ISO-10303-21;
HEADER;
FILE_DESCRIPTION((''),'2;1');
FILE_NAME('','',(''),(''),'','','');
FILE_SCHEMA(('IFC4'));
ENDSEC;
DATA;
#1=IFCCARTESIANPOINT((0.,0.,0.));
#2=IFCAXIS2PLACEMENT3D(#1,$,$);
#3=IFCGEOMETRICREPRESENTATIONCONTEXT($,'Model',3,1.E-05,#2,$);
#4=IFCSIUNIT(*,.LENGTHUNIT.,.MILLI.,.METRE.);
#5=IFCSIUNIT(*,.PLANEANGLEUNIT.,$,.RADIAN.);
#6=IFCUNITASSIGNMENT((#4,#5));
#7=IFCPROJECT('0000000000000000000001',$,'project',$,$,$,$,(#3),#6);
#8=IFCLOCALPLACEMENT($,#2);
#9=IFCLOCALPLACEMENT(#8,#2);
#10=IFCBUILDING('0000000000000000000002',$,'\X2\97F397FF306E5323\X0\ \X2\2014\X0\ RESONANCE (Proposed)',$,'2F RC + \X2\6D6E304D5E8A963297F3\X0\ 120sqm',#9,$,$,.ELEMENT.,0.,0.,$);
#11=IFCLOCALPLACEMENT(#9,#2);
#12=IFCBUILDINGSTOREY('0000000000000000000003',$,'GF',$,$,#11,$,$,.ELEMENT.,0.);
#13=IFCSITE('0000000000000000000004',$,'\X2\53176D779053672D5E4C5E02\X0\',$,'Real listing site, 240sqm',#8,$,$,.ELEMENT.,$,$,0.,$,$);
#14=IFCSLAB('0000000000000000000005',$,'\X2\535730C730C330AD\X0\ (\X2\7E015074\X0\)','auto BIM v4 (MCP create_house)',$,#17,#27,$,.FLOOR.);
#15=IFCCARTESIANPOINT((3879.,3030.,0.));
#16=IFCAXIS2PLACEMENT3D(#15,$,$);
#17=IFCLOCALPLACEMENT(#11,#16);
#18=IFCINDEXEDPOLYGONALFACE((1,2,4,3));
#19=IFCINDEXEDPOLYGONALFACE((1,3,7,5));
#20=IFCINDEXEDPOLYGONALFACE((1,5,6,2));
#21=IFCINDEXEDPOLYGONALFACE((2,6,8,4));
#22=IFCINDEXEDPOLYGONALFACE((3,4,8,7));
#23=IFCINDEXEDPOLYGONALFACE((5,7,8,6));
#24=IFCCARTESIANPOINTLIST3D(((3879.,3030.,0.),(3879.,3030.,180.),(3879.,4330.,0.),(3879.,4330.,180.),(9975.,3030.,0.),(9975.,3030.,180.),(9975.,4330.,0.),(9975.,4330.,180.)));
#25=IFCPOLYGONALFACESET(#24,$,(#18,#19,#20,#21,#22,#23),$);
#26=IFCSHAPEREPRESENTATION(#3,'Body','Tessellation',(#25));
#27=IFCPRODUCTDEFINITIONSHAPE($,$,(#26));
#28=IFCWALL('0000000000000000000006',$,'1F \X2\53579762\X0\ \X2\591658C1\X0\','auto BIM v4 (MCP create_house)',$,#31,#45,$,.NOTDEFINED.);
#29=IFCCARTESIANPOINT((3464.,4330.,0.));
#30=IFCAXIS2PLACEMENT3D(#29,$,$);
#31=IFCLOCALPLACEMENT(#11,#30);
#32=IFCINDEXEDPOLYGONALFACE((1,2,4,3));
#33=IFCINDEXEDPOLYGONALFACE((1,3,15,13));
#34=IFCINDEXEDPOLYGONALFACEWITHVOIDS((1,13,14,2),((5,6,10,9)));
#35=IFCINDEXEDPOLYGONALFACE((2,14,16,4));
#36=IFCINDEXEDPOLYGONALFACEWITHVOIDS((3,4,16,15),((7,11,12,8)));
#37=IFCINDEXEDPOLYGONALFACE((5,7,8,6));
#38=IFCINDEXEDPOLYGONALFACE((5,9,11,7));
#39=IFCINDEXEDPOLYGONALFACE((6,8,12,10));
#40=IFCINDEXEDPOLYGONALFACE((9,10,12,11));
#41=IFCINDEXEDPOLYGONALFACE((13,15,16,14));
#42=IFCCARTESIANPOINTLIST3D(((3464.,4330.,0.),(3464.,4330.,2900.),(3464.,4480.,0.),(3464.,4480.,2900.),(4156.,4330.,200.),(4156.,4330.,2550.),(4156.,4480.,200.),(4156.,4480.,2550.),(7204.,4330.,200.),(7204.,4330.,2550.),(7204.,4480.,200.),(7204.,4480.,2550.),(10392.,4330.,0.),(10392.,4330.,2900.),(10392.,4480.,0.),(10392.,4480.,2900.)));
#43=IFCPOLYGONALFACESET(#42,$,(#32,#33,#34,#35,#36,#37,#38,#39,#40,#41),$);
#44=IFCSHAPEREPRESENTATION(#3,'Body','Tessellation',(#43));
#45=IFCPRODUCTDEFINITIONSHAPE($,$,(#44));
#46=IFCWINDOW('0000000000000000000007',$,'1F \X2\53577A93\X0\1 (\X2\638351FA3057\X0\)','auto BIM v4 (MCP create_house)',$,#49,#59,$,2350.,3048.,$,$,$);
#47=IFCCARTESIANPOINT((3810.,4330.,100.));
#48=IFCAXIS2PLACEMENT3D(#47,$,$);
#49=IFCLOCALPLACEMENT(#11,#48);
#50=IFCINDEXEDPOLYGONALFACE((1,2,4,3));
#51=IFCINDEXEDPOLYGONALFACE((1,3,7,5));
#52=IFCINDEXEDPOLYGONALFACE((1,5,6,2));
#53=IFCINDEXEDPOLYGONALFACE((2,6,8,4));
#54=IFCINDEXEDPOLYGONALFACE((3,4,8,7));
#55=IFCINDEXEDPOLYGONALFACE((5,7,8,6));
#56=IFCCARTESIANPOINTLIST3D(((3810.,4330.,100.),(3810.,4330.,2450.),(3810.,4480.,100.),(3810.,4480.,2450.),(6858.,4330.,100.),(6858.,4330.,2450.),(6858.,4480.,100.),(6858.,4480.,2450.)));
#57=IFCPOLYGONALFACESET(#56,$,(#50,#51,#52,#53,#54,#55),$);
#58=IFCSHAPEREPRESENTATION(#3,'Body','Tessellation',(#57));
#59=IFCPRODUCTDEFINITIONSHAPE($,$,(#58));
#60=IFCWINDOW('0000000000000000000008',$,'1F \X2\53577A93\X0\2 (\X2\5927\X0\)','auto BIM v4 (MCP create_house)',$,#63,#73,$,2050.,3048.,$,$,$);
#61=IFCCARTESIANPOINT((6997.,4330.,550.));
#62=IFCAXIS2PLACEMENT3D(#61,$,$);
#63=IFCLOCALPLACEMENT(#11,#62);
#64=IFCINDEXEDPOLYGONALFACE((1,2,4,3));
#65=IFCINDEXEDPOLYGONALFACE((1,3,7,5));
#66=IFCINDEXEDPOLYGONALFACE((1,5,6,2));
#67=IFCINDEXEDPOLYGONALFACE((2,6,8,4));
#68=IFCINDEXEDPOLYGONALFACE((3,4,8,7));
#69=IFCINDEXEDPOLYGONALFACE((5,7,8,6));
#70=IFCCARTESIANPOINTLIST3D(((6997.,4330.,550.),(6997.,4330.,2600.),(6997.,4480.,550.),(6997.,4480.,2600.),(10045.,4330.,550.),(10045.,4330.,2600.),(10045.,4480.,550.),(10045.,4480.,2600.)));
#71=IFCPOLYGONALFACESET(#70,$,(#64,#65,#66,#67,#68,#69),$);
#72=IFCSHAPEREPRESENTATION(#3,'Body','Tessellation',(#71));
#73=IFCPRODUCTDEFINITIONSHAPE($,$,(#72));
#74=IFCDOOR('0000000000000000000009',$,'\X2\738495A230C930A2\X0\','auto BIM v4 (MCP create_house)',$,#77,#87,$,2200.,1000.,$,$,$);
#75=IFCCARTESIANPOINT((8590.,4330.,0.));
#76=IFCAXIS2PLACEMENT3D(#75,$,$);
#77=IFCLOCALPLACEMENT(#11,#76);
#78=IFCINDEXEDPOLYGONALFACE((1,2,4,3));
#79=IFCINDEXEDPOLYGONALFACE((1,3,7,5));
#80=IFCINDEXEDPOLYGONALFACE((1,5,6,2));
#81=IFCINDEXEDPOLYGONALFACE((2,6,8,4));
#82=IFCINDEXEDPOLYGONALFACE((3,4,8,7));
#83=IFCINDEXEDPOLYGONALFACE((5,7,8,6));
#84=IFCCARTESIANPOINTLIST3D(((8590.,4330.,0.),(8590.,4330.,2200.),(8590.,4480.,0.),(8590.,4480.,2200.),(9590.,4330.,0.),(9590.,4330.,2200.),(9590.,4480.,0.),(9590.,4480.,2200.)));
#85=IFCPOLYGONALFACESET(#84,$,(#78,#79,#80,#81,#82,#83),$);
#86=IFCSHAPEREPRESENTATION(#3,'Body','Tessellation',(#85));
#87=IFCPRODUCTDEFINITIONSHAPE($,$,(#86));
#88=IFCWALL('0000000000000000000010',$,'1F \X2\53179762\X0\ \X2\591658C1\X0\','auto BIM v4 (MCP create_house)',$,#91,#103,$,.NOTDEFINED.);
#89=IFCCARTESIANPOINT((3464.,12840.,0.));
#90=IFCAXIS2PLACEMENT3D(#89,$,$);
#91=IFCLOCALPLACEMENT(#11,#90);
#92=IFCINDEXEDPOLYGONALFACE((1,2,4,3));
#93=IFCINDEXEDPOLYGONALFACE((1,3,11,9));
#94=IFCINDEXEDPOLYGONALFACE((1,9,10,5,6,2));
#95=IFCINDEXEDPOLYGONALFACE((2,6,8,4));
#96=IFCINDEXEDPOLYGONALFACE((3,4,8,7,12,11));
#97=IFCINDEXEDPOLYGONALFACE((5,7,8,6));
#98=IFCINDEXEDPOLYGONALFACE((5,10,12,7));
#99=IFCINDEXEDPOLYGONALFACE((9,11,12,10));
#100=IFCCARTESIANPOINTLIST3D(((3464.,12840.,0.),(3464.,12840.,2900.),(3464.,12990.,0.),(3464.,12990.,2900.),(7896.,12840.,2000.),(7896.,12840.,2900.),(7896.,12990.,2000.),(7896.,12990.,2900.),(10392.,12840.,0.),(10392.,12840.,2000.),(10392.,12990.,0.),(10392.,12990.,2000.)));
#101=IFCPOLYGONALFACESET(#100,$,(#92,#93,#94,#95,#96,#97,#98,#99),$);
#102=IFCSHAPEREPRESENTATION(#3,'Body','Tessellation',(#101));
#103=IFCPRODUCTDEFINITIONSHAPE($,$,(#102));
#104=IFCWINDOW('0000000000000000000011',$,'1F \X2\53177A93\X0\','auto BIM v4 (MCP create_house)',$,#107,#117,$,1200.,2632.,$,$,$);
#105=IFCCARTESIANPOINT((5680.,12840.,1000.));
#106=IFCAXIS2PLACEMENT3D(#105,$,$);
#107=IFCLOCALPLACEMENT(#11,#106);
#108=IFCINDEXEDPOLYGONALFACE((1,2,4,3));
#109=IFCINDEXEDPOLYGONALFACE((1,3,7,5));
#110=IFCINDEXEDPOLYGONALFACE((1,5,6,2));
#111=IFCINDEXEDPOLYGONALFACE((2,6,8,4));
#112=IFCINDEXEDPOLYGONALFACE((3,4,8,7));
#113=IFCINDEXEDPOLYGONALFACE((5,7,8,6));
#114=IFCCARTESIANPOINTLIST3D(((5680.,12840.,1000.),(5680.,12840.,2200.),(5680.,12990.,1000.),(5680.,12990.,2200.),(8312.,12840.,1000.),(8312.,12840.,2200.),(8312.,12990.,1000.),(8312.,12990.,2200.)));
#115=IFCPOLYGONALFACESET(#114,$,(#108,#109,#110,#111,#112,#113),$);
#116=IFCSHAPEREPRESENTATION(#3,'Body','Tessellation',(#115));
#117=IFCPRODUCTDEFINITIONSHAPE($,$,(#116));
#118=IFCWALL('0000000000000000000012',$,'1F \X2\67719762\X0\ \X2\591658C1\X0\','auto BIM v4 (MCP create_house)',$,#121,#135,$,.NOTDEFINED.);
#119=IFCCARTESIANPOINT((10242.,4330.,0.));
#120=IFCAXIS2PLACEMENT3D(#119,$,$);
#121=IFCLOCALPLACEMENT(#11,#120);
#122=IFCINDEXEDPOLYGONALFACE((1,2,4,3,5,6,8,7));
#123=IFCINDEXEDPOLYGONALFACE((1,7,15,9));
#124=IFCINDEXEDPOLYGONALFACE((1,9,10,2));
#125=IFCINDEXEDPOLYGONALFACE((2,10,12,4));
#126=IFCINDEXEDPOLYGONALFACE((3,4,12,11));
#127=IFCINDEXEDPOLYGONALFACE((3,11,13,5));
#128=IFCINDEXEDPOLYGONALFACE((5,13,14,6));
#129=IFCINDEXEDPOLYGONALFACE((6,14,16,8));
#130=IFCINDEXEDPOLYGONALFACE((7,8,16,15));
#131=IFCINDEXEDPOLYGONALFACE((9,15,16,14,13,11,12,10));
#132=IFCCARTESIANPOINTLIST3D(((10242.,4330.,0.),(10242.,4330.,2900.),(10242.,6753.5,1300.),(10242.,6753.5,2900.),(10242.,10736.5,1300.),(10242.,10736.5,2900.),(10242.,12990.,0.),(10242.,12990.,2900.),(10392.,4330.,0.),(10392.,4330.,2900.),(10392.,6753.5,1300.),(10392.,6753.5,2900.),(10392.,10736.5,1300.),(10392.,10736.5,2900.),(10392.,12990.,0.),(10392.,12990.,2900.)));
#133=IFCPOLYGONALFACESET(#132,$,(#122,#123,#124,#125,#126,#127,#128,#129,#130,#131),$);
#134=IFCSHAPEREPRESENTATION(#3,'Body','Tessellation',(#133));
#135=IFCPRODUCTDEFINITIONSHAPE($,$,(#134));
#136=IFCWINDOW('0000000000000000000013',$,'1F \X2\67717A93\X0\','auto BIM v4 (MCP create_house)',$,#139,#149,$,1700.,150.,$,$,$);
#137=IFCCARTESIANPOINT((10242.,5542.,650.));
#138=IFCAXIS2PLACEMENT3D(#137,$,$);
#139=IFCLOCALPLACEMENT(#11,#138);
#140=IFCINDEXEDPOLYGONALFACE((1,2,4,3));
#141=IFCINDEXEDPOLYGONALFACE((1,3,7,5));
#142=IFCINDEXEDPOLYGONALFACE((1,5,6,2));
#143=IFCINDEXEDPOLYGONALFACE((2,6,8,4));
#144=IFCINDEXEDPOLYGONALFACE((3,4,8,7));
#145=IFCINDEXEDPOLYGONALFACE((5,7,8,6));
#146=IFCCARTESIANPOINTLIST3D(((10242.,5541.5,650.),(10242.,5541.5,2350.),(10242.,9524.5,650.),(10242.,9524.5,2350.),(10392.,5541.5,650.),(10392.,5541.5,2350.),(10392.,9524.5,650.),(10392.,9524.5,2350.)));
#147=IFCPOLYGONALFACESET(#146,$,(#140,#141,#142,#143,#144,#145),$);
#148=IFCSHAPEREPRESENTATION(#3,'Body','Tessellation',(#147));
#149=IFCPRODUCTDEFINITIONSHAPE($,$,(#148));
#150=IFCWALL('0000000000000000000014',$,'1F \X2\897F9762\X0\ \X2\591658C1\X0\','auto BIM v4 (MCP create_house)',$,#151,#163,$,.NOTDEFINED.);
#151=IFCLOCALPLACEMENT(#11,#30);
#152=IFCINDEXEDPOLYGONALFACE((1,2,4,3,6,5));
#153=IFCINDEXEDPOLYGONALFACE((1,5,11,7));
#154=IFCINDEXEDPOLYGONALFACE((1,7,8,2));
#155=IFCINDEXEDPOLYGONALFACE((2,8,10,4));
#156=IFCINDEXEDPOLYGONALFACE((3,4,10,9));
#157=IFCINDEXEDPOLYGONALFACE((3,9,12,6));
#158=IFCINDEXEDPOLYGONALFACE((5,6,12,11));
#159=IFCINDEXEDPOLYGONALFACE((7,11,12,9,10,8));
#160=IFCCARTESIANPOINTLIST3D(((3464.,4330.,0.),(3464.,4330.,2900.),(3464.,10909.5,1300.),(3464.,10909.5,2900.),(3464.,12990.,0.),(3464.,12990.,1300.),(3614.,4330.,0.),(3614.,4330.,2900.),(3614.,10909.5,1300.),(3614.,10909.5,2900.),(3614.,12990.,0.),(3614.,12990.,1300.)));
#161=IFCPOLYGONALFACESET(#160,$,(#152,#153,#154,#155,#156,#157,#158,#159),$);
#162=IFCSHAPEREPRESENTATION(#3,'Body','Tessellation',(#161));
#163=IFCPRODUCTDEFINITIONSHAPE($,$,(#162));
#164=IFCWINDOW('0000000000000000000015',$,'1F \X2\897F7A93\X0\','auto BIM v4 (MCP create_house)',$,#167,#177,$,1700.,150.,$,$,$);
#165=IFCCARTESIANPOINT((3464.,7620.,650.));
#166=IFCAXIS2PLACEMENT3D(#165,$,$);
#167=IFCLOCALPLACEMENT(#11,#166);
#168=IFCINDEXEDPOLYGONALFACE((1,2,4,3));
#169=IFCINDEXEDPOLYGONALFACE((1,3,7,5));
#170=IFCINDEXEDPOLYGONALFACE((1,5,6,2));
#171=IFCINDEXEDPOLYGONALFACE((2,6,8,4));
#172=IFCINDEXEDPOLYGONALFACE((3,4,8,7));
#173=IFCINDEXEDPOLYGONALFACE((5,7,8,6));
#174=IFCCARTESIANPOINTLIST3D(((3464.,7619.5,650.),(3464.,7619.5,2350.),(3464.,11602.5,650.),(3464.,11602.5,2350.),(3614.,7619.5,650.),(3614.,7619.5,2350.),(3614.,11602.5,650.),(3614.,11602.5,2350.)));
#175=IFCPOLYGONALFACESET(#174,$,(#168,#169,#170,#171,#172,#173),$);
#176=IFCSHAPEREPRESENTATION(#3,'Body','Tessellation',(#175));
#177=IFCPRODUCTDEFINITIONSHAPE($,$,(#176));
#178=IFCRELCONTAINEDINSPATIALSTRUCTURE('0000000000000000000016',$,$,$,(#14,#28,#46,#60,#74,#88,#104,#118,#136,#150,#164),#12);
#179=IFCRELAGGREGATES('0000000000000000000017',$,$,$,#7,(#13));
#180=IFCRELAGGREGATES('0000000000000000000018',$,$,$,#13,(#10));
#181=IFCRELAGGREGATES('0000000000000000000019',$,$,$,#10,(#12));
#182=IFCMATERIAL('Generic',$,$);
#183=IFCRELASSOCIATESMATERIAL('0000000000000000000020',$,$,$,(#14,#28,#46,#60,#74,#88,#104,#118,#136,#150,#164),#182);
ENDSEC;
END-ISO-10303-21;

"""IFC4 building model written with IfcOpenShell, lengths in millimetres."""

from ifc_helpers import new_model, si_unit, frame, frame_2d, origin, place, context, project, spatial, rectangle, extrude, material, element, fill, save


model = new_model("IFC4")

# Units and contexts
model_context = context("Model", 3, precision=1e-05, world=origin())
ifc_project = project(units=[si_unit("LENGTHUNIT", "METRE", prefix="MILLI"), si_unit("PLANEANGLEUNIT", "RADIAN")], contexts=[model_context])

# Site, building, storey
site_placement = place(None, origin())
site = spatial("IfcSite", under=ifc_project, at=site_placement, Name="北海道札幌市", ObjectType="Real listing site, 240sqm", CompositionType="ELEMENT", RefElevation=0.0)
building_placement = place(site_placement, origin())
building = spatial("IfcBuilding", under=site, at=building_placement, Name="音響の匣 — RESONANCE (Proposed)", ObjectType="2F RC + 浮き床防音 120sqm", CompositionType="ELEMENT", ElevationOfRefHeight=0.0, ElevationOfTerrain=0.0)
storey_placement = place(building_placement, origin())
storey = spatial("IfcBuildingStorey", under=building, at=storey_placement, Name="GF", CompositionType="ELEMENT", Elevation=0.0)

# Slab
ifc_material = material(Name="Generic")
slab_1_placement = place(storey_placement, frame((3879.0, 3030.0, 0.0)))
element("IfcSlab", 1, at=slab_1_placement, inside=storey, material=ifc_material, Name="南デッキ (縁側)", Description="auto BIM v4 (MCP create_house)", PredefinedType="FLOOR", context=model_context, shape_type="SweptSolid", body=[
    extrude(rectangle(XDim=6096.0, YDim=1300.0, at=frame_2d((3048.0, 650.0))), frame((3879.0, 3030.0, 0.0)), (0.0, 0.0, 1.0), 180.0),
])

# Wall, openings, windows, door
wall_1_placement = place(storey_placement, frame((3464.0, 4330.0, 0.0)))
wall_1 = element("IfcWall", 2, at=wall_1_placement, inside=storey, material=ifc_material, Name="1F 南面 外壁", Description="auto BIM v4 (MCP create_house)", PredefinedType="NOTDEFINED", context=model_context, shape_type="SweptSolid", body=[
    extrude(rectangle(XDim=6928.0, YDim=150.0, at=frame_2d((3464.0, 75.0))), frame((3464.0, 4330.0, 0.0)), (0.0, 0.0, 1.0), 2900.0),
])
opening_1_placement = place(storey_placement, frame((3810.0, 4330.0, 100.0)))
opening_1 = element("IfcOpeningElement", 3, at=opening_1_placement, cuts=wall_1, PredefinedType="NOTDEFINED", context=model_context, shape_type="SweptSolid", body=[
    extrude(rectangle(XDim=3048.0, YDim=150.0, at=frame_2d((1524.0, 75.0))), frame((3810.0, 4330.0, 100.0)), (0.0, 0.0, 1.0), 2350.0),
])
opening_2_placement = place(storey_placement, frame((6997.0, 4330.0, 550.0)))
opening_2 = element("IfcOpeningElement", 4, at=opening_2_placement, cuts=wall_1, PredefinedType="NOTDEFINED", context=model_context, shape_type="SweptSolid", body=[
    extrude(rectangle(XDim=3048.0, YDim=150.0, at=frame_2d((1524.0, 75.0))), frame((6997.0, 4330.0, 550.0)), (0.0, 0.0, 1.0), 2050.0),
])
opening_3_placement = place(storey_placement, frame((8590.0, 4330.0, 0.0)))
opening_3 = element("IfcOpeningElement", 5, at=opening_3_placement, cuts=wall_1, PredefinedType="NOTDEFINED", context=model_context, shape_type="SweptSolid", body=[
    extrude(rectangle(XDim=1000.0, YDim=150.0, at=frame_2d((500.0, 75.0))), frame((8590.0, 4330.0, 0.0)), (0.0, 0.0, 1.0), 2200.0),
])
window_1_placement = place(storey_placement, frame((3810.0, 4330.0, 100.0)))
window_1 = element("IfcWindow", 6, at=window_1_placement, inside=storey, material=ifc_material, Name="1F 南窓1 (掃出し)", Description="auto BIM v4 (MCP create_house)", OverallHeight=2350.0, OverallWidth=3048.0, context=model_context, shape_type="SweptSolid", body=[
    extrude(rectangle(XDim=3048.0, YDim=150.0, at=frame_2d((1524.0, 75.0))), frame((3810.0, 4330.0, 100.0)), (0.0, 0.0, 1.0), 2350.0),
])
fill(opening_1, window_1)
window_2_placement = place(storey_placement, frame((6997.0, 4330.0, 550.0)))
window_2 = element("IfcWindow", 7, at=window_2_placement, inside=storey, material=ifc_material, Name="1F 南窓2 (大)", Description="auto BIM v4 (MCP create_house)", OverallHeight=2050.0, OverallWidth=3048.0, context=model_context, shape_type="SweptSolid", body=[
    extrude(rectangle(XDim=3048.0, YDim=150.0, at=frame_2d((1524.0, 75.0))), frame((6997.0, 4330.0, 550.0)), (0.0, 0.0, 1.0), 2050.0),
])
fill(opening_2, window_2)
door_1_placement = place(storey_placement, frame((8590.0, 4330.0, 0.0)))
door_1 = element("IfcDoor", 8, at=door_1_placement, inside=storey, material=ifc_material, Name="玄関ドア", Description="auto BIM v4 (MCP create_house)", OverallHeight=2200.0, OverallWidth=1000.0, context=model_context, shape_type="SweptSolid", body=[
    extrude(rectangle(XDim=1000.0, YDim=150.0, at=frame_2d((500.0, 75.0))), frame((8590.0, 4330.0, 0.0)), (0.0, 0.0, 1.0), 2200.0),
])
fill(opening_3, door_1)

# Walls, openings, windows
wall_2_placement = place(storey_placement, frame((3464.0, 12840.0, 0.0)))
wall_2 = element("IfcWall", 9, at=wall_2_placement, inside=storey, material=ifc_material, Name="1F 北面 外壁", Description="auto BIM v4 (MCP create_house)", PredefinedType="NOTDEFINED", context=model_context, shape_type="SweptSolid", body=[
    extrude(rectangle(XDim=6928.0, YDim=150.0, at=frame_2d((3464.0, 75.0))), frame((3464.0, 12840.0, 0.0)), (0.0, 0.0, 1.0), 2900.0),
])
opening_4_placement = place(storey_placement, frame((5680.0, 12840.0, 1000.0)))
opening_4 = element("IfcOpeningElement", 10, at=opening_4_placement, cuts=wall_2, PredefinedType="NOTDEFINED", context=model_context, shape_type="SweptSolid", body=[
    extrude(rectangle(XDim=2632.0, YDim=150.0, at=frame_2d((1316.0, 75.0))), frame((5680.0, 12840.0, 1000.0)), (0.0, 0.0, 1.0), 1200.0),
])
window_3_placement = place(storey_placement, frame((5680.0, 12840.0, 1000.0)))
window_3 = element("IfcWindow", 11, at=window_3_placement, inside=storey, material=ifc_material, Name="1F 北窓", Description="auto BIM v4 (MCP create_house)", OverallHeight=1200.0, OverallWidth=2632.0, context=model_context, shape_type="SweptSolid", body=[
    extrude(rectangle(XDim=2632.0, YDim=150.0, at=frame_2d((1316.0, 75.0))), frame((5680.0, 12840.0, 1000.0)), (0.0, 0.0, 1.0), 1200.0),
])
fill(opening_4, window_3)
wall_3_placement = place(storey_placement, frame((10242.0, 4330.0, 0.0)))
wall_3 = element("IfcWall", 12, at=wall_3_placement, inside=storey, material=ifc_material, Name="1F 東面 外壁", Description="auto BIM v4 (MCP create_house)", PredefinedType="NOTDEFINED", context=model_context, shape_type="SweptSolid", body=[
    extrude(rectangle(XDim=150.0, YDim=8660.0, at=frame_2d((75.0, 4330.0))), frame((10242.0, 4330.0, 0.0)), (0.0, 0.0, 1.0), 2900.0),
])
opening_5_placement = place(storey_placement, frame((10242.0, 5542.0, 650.0)))
opening_5 = element("IfcOpeningElement", 13, at=opening_5_placement, cuts=wall_3, PredefinedType="NOTDEFINED", context=model_context, shape_type="SweptSolid", body=[
    extrude(rectangle(XDim=150.0, YDim=3983.0, at=frame_2d((75.0, 1991.0))), frame((10242.0, 5542.0, 650.0)), (0.0, 0.0, 1.0), 1700.0),
])
window_4_placement = place(storey_placement, frame((10242.0, 5542.0, 650.0)))
window_4 = element("IfcWindow", 14, at=window_4_placement, inside=storey, material=ifc_material, Name="1F 東窓", Description="auto BIM v4 (MCP create_house)", OverallHeight=1700.0, OverallWidth=150.0, context=model_context, shape_type="SweptSolid", body=[
    extrude(rectangle(XDim=150.0, YDim=3983.0, at=frame_2d((75.0, 1991.0))), frame((10242.0, 5542.0, 650.0)), (0.0, 0.0, 1.0), 1700.0),
])
fill(opening_5, window_4)
wall_4_placement = place(storey_placement, frame((3464.0, 4330.0, 0.0)))
wall_4 = element("IfcWall", 15, at=wall_4_placement, inside=storey, material=ifc_material, Name="1F 西面 外壁", Description="auto BIM v4 (MCP create_house)", PredefinedType="NOTDEFINED", context=model_context, shape_type="SweptSolid", body=[
    extrude(rectangle(XDim=150.0, YDim=8660.0, at=frame_2d((75.0, 4330.0))), frame((3464.0, 4330.0, 0.0)), (0.0, 0.0, 1.0), 2900.0),
])
opening_6_placement = place(storey_placement, frame((3464.0, 7620.0, 650.0)))
opening_6 = element("IfcOpeningElement", 16, at=opening_6_placement, cuts=wall_4, PredefinedType="NOTDEFINED", context=model_context, shape_type="SweptSolid", body=[
    extrude(rectangle(XDim=150.0, YDim=3983.0, at=frame_2d((75.0, 1991.0))), frame((3464.0, 7620.0, 650.0)), (0.0, 0.0, 1.0), 1700.0),
])
window_5_placement = place(storey_placement, frame((3464.0, 7620.0, 650.0)))
window_5 = element("IfcWindow", 17, at=window_5_placement, inside=storey, material=ifc_material, Name="1F 西窓", Description="auto BIM v4 (MCP create_house)", OverallHeight=1700.0, OverallWidth=150.0, context=model_context, shape_type="SweptSolid", body=[
    extrude(rectangle(XDim=150.0, YDim=3983.0, at=frame_2d((75.0, 1991.0))), frame((3464.0, 7620.0, 650.0)), (0.0, 0.0, 1.0), 1700.0),
])
fill(opening_6, window_5)

save(model, "model.ifc")
